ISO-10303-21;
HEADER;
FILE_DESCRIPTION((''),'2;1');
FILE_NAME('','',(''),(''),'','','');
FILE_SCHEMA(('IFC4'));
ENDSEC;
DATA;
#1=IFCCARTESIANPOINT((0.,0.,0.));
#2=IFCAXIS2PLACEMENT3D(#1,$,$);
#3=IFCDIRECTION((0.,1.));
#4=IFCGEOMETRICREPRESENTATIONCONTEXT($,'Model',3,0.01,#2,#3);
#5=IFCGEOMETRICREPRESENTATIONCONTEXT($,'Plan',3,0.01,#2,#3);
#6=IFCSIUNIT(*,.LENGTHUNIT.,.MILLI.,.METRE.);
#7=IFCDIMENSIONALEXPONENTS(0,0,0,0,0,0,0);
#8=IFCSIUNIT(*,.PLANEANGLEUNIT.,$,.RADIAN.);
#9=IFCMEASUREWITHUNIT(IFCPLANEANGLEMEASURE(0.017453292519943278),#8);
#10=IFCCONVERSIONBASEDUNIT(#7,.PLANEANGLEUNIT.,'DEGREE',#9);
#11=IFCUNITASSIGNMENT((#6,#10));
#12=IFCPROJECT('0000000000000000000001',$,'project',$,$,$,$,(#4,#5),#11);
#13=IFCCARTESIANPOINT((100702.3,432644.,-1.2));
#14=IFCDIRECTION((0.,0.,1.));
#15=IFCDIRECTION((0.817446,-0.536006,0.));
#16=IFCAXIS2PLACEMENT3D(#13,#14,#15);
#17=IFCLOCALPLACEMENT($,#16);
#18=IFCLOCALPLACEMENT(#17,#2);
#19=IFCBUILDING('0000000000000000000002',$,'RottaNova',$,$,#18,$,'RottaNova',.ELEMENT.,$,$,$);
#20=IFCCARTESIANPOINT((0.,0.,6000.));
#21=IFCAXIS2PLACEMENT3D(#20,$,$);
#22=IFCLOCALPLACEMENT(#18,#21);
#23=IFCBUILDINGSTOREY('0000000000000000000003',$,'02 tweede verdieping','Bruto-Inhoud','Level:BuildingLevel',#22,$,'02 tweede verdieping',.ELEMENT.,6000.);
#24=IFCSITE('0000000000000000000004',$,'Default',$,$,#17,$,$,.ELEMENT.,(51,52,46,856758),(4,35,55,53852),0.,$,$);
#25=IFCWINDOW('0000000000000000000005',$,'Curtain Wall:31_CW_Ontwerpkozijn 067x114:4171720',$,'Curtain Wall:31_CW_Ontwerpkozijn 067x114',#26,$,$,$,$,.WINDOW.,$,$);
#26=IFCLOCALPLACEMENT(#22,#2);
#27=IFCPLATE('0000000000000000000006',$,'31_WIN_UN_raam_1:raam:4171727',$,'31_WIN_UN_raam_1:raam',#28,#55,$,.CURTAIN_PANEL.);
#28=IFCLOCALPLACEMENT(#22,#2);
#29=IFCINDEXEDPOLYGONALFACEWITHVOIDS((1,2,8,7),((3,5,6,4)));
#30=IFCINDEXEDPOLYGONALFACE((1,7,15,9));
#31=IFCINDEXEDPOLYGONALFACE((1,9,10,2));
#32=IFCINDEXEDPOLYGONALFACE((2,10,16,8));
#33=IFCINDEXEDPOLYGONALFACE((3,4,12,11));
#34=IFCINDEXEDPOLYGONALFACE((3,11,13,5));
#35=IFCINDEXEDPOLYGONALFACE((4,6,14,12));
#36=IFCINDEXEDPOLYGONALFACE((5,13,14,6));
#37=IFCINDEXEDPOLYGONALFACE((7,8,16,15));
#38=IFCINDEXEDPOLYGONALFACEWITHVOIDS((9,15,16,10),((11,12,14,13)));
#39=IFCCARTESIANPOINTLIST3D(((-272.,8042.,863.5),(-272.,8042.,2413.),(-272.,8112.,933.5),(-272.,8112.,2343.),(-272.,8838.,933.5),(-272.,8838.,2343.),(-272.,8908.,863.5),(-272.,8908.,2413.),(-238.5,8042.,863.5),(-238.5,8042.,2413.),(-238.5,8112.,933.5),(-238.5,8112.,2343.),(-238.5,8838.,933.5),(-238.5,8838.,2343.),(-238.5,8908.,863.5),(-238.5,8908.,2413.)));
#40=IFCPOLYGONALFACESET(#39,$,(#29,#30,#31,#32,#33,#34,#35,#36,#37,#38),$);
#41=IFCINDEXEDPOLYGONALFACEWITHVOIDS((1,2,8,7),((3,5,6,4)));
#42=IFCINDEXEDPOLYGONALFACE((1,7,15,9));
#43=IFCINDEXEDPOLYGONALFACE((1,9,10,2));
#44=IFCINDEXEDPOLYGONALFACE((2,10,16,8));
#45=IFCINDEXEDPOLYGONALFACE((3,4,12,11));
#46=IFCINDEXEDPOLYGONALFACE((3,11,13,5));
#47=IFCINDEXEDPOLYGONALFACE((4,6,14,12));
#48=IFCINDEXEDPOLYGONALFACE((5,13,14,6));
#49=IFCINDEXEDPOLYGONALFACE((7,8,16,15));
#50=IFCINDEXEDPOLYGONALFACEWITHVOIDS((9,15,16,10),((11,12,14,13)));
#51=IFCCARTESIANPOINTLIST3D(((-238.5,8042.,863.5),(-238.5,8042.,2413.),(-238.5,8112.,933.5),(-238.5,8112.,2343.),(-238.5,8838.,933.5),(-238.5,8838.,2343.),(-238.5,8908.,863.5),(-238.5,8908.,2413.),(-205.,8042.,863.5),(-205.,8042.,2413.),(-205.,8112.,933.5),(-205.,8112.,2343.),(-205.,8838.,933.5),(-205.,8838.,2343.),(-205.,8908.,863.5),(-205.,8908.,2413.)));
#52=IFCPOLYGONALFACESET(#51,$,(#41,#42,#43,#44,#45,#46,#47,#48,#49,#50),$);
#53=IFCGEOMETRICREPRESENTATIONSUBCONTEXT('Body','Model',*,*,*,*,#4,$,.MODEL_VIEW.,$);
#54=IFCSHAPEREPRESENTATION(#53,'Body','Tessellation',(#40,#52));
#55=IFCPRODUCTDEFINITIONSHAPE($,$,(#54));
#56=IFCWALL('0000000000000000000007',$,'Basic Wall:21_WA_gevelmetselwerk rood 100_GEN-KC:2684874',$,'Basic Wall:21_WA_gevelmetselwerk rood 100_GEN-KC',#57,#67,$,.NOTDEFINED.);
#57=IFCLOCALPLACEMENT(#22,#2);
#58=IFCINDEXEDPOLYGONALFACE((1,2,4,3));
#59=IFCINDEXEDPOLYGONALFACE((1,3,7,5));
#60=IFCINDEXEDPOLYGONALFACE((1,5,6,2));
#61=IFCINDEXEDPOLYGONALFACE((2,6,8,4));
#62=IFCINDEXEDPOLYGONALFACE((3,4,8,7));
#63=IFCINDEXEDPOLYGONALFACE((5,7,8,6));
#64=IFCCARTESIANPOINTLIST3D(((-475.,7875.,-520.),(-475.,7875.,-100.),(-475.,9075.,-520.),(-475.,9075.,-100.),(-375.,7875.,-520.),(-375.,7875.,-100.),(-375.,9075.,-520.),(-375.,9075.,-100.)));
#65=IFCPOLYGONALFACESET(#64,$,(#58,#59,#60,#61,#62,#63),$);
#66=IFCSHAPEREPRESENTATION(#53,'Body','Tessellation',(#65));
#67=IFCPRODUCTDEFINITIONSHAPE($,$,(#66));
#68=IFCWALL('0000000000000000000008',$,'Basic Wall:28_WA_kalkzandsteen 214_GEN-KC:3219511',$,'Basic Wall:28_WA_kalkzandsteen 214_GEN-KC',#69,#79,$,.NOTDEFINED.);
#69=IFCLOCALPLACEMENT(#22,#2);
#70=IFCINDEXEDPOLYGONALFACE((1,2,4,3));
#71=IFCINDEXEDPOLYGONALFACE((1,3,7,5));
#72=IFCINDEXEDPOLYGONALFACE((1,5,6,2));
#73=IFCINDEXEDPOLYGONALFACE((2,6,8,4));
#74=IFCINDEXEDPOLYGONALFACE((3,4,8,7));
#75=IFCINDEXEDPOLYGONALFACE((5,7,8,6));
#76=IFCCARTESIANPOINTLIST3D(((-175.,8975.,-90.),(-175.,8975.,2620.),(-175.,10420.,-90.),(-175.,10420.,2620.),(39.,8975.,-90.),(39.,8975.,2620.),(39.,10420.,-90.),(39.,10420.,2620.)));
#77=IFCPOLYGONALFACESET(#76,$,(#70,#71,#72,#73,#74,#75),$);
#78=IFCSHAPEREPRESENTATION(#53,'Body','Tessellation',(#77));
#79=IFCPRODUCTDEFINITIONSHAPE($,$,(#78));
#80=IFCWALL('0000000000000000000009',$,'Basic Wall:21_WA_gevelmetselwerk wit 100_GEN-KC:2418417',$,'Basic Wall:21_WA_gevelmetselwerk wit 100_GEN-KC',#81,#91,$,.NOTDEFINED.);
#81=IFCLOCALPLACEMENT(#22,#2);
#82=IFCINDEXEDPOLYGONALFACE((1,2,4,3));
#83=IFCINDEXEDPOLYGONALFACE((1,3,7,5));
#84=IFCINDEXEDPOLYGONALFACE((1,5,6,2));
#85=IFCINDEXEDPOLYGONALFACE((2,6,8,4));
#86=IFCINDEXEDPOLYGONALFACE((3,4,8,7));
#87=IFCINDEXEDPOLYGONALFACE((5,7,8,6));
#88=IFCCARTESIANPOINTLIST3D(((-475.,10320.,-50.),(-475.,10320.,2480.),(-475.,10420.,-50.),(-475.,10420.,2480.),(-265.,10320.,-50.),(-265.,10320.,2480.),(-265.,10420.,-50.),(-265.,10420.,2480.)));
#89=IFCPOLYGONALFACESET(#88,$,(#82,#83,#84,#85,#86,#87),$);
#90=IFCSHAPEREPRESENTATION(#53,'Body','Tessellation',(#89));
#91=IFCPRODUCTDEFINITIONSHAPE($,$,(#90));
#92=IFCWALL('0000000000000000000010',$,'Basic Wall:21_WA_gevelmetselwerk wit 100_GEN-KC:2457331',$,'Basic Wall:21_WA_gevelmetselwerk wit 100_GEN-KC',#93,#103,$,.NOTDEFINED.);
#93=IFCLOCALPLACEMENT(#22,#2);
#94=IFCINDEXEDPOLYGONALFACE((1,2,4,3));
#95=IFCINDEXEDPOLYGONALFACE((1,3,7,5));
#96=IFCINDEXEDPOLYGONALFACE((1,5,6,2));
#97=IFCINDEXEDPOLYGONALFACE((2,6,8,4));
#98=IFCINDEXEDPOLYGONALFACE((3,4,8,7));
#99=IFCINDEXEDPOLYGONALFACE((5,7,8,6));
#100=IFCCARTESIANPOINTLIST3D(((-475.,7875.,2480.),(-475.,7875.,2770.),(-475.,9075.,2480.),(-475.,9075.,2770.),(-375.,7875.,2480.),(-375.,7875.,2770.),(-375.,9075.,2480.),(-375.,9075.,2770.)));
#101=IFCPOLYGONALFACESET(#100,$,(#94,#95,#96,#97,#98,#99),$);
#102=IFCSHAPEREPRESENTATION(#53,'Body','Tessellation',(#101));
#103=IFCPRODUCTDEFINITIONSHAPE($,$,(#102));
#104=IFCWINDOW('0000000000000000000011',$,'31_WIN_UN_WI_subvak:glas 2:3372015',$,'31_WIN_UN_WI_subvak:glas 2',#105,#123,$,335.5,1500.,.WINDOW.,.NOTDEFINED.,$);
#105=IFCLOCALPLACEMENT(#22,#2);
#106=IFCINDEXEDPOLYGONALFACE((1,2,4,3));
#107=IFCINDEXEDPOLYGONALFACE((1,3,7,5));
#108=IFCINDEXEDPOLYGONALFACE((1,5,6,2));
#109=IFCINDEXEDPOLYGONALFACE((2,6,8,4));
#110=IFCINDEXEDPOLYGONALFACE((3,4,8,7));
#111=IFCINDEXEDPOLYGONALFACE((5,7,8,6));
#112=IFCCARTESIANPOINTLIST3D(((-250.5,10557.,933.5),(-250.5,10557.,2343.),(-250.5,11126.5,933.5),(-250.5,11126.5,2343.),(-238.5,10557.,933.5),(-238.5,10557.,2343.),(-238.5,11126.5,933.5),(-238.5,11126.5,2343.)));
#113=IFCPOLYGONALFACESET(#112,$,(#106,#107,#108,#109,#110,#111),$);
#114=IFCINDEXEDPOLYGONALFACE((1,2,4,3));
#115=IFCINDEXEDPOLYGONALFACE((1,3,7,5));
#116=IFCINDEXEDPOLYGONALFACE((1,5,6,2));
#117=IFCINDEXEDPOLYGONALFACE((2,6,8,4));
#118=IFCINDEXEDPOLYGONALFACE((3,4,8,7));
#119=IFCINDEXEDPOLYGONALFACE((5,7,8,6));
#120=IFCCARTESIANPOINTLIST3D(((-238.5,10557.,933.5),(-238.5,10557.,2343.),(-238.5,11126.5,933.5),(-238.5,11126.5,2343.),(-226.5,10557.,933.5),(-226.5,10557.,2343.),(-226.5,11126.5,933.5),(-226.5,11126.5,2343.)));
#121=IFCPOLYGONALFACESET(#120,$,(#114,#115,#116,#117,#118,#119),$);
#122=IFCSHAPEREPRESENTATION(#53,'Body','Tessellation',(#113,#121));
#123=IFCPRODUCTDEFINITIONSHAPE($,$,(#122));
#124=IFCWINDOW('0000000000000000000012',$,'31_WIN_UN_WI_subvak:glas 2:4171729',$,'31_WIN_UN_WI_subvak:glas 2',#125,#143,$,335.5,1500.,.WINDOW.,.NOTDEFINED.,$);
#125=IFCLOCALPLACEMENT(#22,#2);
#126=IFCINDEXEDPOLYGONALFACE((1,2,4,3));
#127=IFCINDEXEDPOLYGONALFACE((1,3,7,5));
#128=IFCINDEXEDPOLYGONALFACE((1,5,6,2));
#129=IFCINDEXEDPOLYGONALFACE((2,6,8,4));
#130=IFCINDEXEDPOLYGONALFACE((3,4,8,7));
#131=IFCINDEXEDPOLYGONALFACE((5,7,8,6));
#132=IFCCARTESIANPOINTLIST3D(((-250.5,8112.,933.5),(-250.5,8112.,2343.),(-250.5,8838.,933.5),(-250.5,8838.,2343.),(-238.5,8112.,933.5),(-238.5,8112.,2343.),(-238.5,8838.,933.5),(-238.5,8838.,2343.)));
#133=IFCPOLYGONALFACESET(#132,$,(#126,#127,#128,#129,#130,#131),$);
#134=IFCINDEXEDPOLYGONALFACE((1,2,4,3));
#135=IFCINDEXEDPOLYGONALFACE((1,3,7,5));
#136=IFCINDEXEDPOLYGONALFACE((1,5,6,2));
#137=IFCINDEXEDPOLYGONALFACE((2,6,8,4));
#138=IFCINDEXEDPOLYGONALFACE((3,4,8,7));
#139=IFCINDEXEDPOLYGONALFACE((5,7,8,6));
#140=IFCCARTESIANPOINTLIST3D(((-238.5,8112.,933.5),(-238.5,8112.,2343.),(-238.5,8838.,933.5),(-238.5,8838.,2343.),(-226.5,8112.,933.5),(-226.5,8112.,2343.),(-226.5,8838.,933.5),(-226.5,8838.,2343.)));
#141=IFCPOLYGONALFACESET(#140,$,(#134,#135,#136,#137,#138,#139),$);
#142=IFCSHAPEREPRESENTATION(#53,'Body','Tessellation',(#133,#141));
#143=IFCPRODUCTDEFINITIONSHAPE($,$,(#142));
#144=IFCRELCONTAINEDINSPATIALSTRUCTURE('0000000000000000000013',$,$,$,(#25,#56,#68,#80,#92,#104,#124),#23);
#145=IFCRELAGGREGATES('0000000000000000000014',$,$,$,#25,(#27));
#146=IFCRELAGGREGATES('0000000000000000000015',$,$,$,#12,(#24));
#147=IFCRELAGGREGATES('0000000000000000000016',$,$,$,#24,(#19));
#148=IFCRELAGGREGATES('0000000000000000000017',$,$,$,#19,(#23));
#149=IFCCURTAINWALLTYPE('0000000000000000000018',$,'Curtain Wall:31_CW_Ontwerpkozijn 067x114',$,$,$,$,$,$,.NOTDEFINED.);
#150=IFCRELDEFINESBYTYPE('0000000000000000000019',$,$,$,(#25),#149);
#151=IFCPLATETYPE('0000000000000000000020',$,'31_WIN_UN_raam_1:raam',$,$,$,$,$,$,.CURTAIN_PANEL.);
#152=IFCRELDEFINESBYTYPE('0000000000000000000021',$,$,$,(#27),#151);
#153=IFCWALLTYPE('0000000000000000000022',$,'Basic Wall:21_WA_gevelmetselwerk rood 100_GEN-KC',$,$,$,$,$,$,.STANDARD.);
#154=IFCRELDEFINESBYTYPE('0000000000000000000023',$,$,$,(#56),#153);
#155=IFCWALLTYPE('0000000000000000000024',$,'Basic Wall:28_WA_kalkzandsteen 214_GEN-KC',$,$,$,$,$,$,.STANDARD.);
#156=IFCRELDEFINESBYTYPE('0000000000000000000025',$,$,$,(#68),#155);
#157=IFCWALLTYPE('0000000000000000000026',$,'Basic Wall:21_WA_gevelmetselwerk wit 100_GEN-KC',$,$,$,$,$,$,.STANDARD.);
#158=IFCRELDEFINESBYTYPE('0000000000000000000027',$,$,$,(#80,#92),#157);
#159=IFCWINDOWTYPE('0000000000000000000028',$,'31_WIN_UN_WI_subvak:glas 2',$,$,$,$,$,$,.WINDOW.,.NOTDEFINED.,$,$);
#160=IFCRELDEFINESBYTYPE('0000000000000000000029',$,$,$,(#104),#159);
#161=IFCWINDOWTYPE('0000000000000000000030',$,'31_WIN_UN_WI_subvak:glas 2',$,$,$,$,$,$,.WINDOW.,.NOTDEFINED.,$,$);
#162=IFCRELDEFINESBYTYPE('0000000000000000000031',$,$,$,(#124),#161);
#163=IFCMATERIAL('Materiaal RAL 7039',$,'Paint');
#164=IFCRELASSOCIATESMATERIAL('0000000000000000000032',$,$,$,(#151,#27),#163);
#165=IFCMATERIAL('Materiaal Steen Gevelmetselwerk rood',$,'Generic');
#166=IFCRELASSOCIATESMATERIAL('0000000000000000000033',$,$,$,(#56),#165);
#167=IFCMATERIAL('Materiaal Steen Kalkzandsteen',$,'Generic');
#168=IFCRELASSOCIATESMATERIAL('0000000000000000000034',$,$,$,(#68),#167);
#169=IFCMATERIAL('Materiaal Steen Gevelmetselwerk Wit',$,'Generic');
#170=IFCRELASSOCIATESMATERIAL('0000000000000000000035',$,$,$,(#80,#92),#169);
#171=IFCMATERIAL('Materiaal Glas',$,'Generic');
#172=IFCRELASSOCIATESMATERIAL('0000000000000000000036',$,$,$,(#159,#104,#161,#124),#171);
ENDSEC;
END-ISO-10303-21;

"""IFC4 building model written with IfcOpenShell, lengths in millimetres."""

from ifc_helpers import new_model, entity, si_unit, converted_unit, direction, frame, origin, place, context, subcontext, project, spatial, indexed_curve, outline, extrude, source, transform, mapped, material, type_object, type_shapes, element, aggregate, save


model = new_model("IFC4")

# Units and contexts
model_context = context("Model", 3, precision=0.01, world=origin(), true_north=direction((0.0, 1.0)))
plan_context = context("Plan", 3, precision=0.01, world=origin(), true_north=direction((0.0, 1.0)))
body_context = subcontext(model_context, "Body", "Model", "MODEL_VIEW")
ifc_project = project(units=[si_unit("LENGTHUNIT", "METRE", prefix="MILLI"), converted_unit("PLANEANGLEUNIT", "DEGREE", entity("IfcPlaneAngleMeasure", 0.017453292519943278), si_unit("PLANEANGLEUNIT", "RADIAN"), dimensions=[0, 0, 0, 0, 0, 0, 0])], contexts=[model_context, plan_context])

# Site, building, storey
site_placement = place(None, frame((100702.3, 432644.0, -1.2), z_axis=(0.0, 0.0, 1.0), x_axis=(0.817446, -0.536006, 0.0)))
site = spatial("IfcSite", under=ifc_project, at=site_placement, Name="Default", CompositionType="ELEMENT", RefLatitude=(51, 52, 46, 856758), RefLongitude=(4, 35, 55, 53852), RefElevation=0.0)
building_placement = place(site_placement, origin())
building = spatial("IfcBuilding", under=site, at=building_placement, Name="RottaNova", LongName="RottaNova", CompositionType="ELEMENT")
storey_placement = place(building_placement, frame((0.0, 0.0, 6000.0)))
storey = spatial("IfcBuildingStorey", under=building, at=storey_placement, Name="02 tweede verdieping", Description="Bruto-Inhoud", ObjectType="Level:BuildingLevel", LongName="02 tweede verdieping", CompositionType="ELEMENT", Elevation=6000.0)

# Window
curtain_wall_type = type_object("IfcCurtainWallType", Name="Curtain Wall:31_CW_Ontwerpkozijn 067x114", PredefinedType="NOTDEFINED")
window_1_placement = place(storey_placement, frame((0.0, 0.0, -6000.0)))
window_1 = element("IfcWindow", 1, at=window_1_placement, inside=storey, type_object=curtain_wall_type, Name="Curtain Wall:31_CW_Ontwerpkozijn 067x114:4171720", ObjectType="Curtain Wall:31_CW_Ontwerpkozijn 067x114", PredefinedType="WINDOW")

# Plate
ifc_material_1 = material(Name="Materiaal Glas", Category="Generic")
ifc_material_2 = material(Name="Materiaal RAL 7039", Category="Paint")
plate_type_1 = type_object("IfcPlateType", Name="31_WIN_UN_raam_1:raam", PredefinedType="CURTAIN_PANEL", material=ifc_material_2)
shared_shape_1 = source(origin(), body_context, "Body", "SweptSolid", [
    extrude(outline(indexed_curve([(-433.0, -774.7), (433.0, -774.7), (433.0, 774.7), (-433.0, 774.7), (-433.0, -774.7)], self_intersect=False), holes=[indexed_curve([(-363.0, 704.7), (363.0, 704.7), (363.0, -704.8), (-363.0, -704.8), (-363.0, 704.7)], self_intersect=False)]), frame((0.0, -92.0, 774.8), z_axis=(0.0, 1.0, 0.0), x_axis=(1.0, 0.0, 0.0)), (0.0, 0.0, 1.0), 33.5),
    extrude(outline(indexed_curve([(-433.0, -774.7), (433.0, -774.7), (433.0, 774.7), (-433.0, 774.7), (-433.0, -774.7)], self_intersect=False), holes=[indexed_curve([(-363.0, 704.7), (363.0, 704.7), (363.0, -704.8), (-363.0, -704.8), (-363.0, 704.7)], self_intersect=False)]), frame((0.0, -58.5, 774.8), z_axis=(0.0, 1.0, 0.0), x_axis=(1.0, 0.0, 0.0)), (0.0, 0.0, 1.0), 33.5),
])
type_shapes(plate_type_1, [shared_shape_1])
plate_1_placement = place(window_1_placement, frame((-180.0, 8475.0, 6863.5), z_axis=(0.0, 0.0, 1.0), x_axis=(0.0, -1.0, 0.0)))
plate_1 = element("IfcPlate", 2, at=plate_1_placement, type_object=plate_type_1, material=ifc_material_2, Name="31_WIN_UN_raam_1:raam:4171727", ObjectType="31_WIN_UN_raam_1:raam", PredefinedType="CURTAIN_PANEL", context=body_context, shape_type="MappedRepresentation", body=[
    mapped(shared_shape_1, transform((0.0, 0.0, 0.0), scale=1.0)),
])
aggregate(window_1, [plate_1])

# Walls
ifc_material_3 = material(Name="Materiaal Steen Gevelmetselwerk rood", Category="Generic")
wall_type_1 = type_object("IfcWallType", Name="Basic Wall:21_WA_gevelmetselwerk rood 100_GEN-KC", PredefinedType="STANDARD")
wall_1_placement = place(storey_placement, frame((-425.0, 9075.0, -520.0), z_axis=(0.0, 0.0, 1.0), x_axis=(0.0, -1.0, 0.0)))
element("IfcWall", 3, at=wall_1_placement, inside=storey, type_object=wall_type_1, material=ifc_material_3, Name="Basic Wall:21_WA_gevelmetselwerk rood 100_GEN-KC:2684874", ObjectType="Basic Wall:21_WA_gevelmetselwerk rood 100_GEN-KC", PredefinedType="NOTDEFINED", context=body_context, shape_type="SweptSolid", body=[
    extrude(outline(indexed_curve([(1200.0, 50.0), (0.0, 50.0), (0.0, -50.0), (1200.0, -50.0), (1200.0, 50.0)], self_intersect=False)), origin(), (0.0, 0.0, 1.0), 420.0),
])
ifc_material_4 = material(Name="Materiaal Steen Kalkzandsteen", Category="Generic")
wall_type_2 = type_object("IfcWallType", Name="Basic Wall:28_WA_kalkzandsteen 214_GEN-KC", PredefinedType="STANDARD")
wall_2_placement = place(storey_placement, frame((-68.0, 8975.0, -90.0), z_axis=(0.0, 0.0, 1.0), x_axis=(0.0, 1.0, 0.0)))
element("IfcWall", 4, at=wall_2_placement, inside=storey, type_object=wall_type_2, material=ifc_material_4, Name="Basic Wall:28_WA_kalkzandsteen 214_GEN-KC:3219511", ObjectType="Basic Wall:28_WA_kalkzandsteen 214_GEN-KC", PredefinedType="NOTDEFINED", context=body_context, shape_type="SweptSolid", body=[
    extrude(outline(indexed_curve([(1445.0, 107.0), (0.0, 107.0), (0.0, -107.0), (1445.0, -107.0), (1445.0, 107.0)], self_intersect=False)), origin(), (0.0, 0.0, 1.0), 2710.0),
])
ifc_material_5 = material(Name="Materiaal Steen Gevelmetselwerk Wit", Category="Generic")
wall_type_3 = type_object("IfcWallType", Name="Basic Wall:21_WA_gevelmetselwerk wit 100_GEN-KC", PredefinedType="STANDARD")
wall_3_placement = place(storey_placement, frame((-265.0, 10370.0, -50.0), z_axis=(0.0, 0.0, 1.0), x_axis=(-1.0, 0.0, 0.0)))
element("IfcWall", 5, at=wall_3_placement, inside=storey, type_object=wall_type_3, material=ifc_material_5, Name="Basic Wall:21_WA_gevelmetselwerk wit 100_GEN-KC:2418417", ObjectType="Basic Wall:21_WA_gevelmetselwerk wit 100_GEN-KC", PredefinedType="NOTDEFINED", context=body_context, shape_type="SweptSolid", body=[
    extrude(outline(indexed_curve([(210.0, 50.0), (0.0, 50.0), (0.0, -50.0), (210.0, -50.0), (210.0, 50.0)], self_intersect=False)), origin(), (0.0, 0.0, 1.0), 2530.0),
])
wall_4_placement = place(storey_placement, frame((-425.0, 9075.0, 2480.0), z_axis=(0.0, 0.0, 1.0), x_axis=(0.0, -1.0, 0.0)))
element("IfcWall", 6, at=wall_4_placement, inside=storey, type_object=wall_type_3, material=ifc_material_5, Name="Basic Wall:21_WA_gevelmetselwerk wit 100_GEN-KC:2457331", ObjectType="Basic Wall:21_WA_gevelmetselwerk wit 100_GEN-KC", PredefinedType="NOTDEFINED", context=body_context, shape_type="SweptSolid", body=[
    extrude(outline(indexed_curve([(1200.0, 50.0), (0.0, 50.0), (0.0, -50.0), (1200.0, -50.0), (1200.0, 50.0)], self_intersect=False)), origin(), (0.0, 0.0, 1.0), 290.0),
])

# Windows
window_type_1 = type_object("IfcWindowType", Name="31_WIN_UN_WI_subvak:glas 2", PartitioningType="NOTDEFINED", PredefinedType="WINDOW", material=ifc_material_1)
shared_shape_2 = source(origin(), body_context, "Body", "SweptSolid", [
    extrude(outline(indexed_curve([(-284.7, -6.0), (284.7, -6.0), (284.7, 6.0), (-284.7, 6.0), (-284.7, -6.0)], self_intersect=False)), frame((0.0, -6.0, 0.0)), (0.0, 0.0, 1.0), 1409.5),
    extrude(outline(indexed_curve([(-284.8, -6.0), (284.8, -6.0), (284.8, 6.0), (-284.8, 6.0), (-284.8, -6.0)], self_intersect=False)), frame((0.0, 6.0, 0.0)), (0.0, 0.0, 1.0), 1409.5),
])
type_shapes(window_type_1, [shared_shape_2])
window_2_placement = place(storey_placement, frame((-238.5, 10841.7, 933.5), z_axis=(0.0, 0.0, 1.0), x_axis=(0.0, -1.0, 0.0)))
element("IfcWindow", 7, at=window_2_placement, inside=storey, type_object=window_type_1, material=ifc_material_1, Name="31_WIN_UN_WI_subvak:glas 2:3372015", ObjectType="31_WIN_UN_WI_subvak:glas 2", OverallHeight=335.5, OverallWidth=1500.0, PartitioningType="NOTDEFINED", PredefinedType="WINDOW", context=body_context, shape_type="MappedRepresentation", body=[
    mapped(shared_shape_2, transform((0.0, 0.0, 0.0), scale=1.0)),
])
window_type_2 = type_object("IfcWindowType", Name="31_WIN_UN_WI_subvak:glas 2", PartitioningType="NOTDEFINED", PredefinedType="WINDOW", material=ifc_material_1)
shared_shape_3 = source(origin(), body_context, "Body", "SweptSolid", [
    extrude(outline(indexed_curve([(-363.0, -6.0), (363.0, -6.0), (363.0, 6.0), (-363.0, 6.0), (-363.0, -6.0)], self_intersect=False)), frame((0.0, -6.0, 0.0)), (0.0, 0.0, 1.0), 1409.5),
    extrude(outline(indexed_curve([(-363.0, -6.0), (363.0, -6.0), (363.0, 6.0), (-363.0, 6.0), (-363.0, -6.0)], self_intersect=False)), frame((0.0, 6.0, 0.0)), (0.0, 0.0, 1.0), 1409.5),
])
type_shapes(window_type_2, [shared_shape_3])
window_3_placement = place(storey_placement, frame((-238.5, 8475.0, 933.5), z_axis=(0.0, 0.0, 1.0), x_axis=(0.0, -1.0, 0.0)))
element("IfcWindow", 8, at=window_3_placement, inside=storey, type_object=window_type_2, material=ifc_material_1, Name="31_WIN_UN_WI_subvak:glas 2:4171729", ObjectType="31_WIN_UN_WI_subvak:glas 2", OverallHeight=335.5, OverallWidth=1500.0, PartitioningType="NOTDEFINED", PredefinedType="WINDOW", context=body_context, shape_type="MappedRepresentation", body=[
    mapped(shared_shape_3, transform((0.0, 0.0, 0.0), scale=1.0)),
])

save(model, "model.ifc")
